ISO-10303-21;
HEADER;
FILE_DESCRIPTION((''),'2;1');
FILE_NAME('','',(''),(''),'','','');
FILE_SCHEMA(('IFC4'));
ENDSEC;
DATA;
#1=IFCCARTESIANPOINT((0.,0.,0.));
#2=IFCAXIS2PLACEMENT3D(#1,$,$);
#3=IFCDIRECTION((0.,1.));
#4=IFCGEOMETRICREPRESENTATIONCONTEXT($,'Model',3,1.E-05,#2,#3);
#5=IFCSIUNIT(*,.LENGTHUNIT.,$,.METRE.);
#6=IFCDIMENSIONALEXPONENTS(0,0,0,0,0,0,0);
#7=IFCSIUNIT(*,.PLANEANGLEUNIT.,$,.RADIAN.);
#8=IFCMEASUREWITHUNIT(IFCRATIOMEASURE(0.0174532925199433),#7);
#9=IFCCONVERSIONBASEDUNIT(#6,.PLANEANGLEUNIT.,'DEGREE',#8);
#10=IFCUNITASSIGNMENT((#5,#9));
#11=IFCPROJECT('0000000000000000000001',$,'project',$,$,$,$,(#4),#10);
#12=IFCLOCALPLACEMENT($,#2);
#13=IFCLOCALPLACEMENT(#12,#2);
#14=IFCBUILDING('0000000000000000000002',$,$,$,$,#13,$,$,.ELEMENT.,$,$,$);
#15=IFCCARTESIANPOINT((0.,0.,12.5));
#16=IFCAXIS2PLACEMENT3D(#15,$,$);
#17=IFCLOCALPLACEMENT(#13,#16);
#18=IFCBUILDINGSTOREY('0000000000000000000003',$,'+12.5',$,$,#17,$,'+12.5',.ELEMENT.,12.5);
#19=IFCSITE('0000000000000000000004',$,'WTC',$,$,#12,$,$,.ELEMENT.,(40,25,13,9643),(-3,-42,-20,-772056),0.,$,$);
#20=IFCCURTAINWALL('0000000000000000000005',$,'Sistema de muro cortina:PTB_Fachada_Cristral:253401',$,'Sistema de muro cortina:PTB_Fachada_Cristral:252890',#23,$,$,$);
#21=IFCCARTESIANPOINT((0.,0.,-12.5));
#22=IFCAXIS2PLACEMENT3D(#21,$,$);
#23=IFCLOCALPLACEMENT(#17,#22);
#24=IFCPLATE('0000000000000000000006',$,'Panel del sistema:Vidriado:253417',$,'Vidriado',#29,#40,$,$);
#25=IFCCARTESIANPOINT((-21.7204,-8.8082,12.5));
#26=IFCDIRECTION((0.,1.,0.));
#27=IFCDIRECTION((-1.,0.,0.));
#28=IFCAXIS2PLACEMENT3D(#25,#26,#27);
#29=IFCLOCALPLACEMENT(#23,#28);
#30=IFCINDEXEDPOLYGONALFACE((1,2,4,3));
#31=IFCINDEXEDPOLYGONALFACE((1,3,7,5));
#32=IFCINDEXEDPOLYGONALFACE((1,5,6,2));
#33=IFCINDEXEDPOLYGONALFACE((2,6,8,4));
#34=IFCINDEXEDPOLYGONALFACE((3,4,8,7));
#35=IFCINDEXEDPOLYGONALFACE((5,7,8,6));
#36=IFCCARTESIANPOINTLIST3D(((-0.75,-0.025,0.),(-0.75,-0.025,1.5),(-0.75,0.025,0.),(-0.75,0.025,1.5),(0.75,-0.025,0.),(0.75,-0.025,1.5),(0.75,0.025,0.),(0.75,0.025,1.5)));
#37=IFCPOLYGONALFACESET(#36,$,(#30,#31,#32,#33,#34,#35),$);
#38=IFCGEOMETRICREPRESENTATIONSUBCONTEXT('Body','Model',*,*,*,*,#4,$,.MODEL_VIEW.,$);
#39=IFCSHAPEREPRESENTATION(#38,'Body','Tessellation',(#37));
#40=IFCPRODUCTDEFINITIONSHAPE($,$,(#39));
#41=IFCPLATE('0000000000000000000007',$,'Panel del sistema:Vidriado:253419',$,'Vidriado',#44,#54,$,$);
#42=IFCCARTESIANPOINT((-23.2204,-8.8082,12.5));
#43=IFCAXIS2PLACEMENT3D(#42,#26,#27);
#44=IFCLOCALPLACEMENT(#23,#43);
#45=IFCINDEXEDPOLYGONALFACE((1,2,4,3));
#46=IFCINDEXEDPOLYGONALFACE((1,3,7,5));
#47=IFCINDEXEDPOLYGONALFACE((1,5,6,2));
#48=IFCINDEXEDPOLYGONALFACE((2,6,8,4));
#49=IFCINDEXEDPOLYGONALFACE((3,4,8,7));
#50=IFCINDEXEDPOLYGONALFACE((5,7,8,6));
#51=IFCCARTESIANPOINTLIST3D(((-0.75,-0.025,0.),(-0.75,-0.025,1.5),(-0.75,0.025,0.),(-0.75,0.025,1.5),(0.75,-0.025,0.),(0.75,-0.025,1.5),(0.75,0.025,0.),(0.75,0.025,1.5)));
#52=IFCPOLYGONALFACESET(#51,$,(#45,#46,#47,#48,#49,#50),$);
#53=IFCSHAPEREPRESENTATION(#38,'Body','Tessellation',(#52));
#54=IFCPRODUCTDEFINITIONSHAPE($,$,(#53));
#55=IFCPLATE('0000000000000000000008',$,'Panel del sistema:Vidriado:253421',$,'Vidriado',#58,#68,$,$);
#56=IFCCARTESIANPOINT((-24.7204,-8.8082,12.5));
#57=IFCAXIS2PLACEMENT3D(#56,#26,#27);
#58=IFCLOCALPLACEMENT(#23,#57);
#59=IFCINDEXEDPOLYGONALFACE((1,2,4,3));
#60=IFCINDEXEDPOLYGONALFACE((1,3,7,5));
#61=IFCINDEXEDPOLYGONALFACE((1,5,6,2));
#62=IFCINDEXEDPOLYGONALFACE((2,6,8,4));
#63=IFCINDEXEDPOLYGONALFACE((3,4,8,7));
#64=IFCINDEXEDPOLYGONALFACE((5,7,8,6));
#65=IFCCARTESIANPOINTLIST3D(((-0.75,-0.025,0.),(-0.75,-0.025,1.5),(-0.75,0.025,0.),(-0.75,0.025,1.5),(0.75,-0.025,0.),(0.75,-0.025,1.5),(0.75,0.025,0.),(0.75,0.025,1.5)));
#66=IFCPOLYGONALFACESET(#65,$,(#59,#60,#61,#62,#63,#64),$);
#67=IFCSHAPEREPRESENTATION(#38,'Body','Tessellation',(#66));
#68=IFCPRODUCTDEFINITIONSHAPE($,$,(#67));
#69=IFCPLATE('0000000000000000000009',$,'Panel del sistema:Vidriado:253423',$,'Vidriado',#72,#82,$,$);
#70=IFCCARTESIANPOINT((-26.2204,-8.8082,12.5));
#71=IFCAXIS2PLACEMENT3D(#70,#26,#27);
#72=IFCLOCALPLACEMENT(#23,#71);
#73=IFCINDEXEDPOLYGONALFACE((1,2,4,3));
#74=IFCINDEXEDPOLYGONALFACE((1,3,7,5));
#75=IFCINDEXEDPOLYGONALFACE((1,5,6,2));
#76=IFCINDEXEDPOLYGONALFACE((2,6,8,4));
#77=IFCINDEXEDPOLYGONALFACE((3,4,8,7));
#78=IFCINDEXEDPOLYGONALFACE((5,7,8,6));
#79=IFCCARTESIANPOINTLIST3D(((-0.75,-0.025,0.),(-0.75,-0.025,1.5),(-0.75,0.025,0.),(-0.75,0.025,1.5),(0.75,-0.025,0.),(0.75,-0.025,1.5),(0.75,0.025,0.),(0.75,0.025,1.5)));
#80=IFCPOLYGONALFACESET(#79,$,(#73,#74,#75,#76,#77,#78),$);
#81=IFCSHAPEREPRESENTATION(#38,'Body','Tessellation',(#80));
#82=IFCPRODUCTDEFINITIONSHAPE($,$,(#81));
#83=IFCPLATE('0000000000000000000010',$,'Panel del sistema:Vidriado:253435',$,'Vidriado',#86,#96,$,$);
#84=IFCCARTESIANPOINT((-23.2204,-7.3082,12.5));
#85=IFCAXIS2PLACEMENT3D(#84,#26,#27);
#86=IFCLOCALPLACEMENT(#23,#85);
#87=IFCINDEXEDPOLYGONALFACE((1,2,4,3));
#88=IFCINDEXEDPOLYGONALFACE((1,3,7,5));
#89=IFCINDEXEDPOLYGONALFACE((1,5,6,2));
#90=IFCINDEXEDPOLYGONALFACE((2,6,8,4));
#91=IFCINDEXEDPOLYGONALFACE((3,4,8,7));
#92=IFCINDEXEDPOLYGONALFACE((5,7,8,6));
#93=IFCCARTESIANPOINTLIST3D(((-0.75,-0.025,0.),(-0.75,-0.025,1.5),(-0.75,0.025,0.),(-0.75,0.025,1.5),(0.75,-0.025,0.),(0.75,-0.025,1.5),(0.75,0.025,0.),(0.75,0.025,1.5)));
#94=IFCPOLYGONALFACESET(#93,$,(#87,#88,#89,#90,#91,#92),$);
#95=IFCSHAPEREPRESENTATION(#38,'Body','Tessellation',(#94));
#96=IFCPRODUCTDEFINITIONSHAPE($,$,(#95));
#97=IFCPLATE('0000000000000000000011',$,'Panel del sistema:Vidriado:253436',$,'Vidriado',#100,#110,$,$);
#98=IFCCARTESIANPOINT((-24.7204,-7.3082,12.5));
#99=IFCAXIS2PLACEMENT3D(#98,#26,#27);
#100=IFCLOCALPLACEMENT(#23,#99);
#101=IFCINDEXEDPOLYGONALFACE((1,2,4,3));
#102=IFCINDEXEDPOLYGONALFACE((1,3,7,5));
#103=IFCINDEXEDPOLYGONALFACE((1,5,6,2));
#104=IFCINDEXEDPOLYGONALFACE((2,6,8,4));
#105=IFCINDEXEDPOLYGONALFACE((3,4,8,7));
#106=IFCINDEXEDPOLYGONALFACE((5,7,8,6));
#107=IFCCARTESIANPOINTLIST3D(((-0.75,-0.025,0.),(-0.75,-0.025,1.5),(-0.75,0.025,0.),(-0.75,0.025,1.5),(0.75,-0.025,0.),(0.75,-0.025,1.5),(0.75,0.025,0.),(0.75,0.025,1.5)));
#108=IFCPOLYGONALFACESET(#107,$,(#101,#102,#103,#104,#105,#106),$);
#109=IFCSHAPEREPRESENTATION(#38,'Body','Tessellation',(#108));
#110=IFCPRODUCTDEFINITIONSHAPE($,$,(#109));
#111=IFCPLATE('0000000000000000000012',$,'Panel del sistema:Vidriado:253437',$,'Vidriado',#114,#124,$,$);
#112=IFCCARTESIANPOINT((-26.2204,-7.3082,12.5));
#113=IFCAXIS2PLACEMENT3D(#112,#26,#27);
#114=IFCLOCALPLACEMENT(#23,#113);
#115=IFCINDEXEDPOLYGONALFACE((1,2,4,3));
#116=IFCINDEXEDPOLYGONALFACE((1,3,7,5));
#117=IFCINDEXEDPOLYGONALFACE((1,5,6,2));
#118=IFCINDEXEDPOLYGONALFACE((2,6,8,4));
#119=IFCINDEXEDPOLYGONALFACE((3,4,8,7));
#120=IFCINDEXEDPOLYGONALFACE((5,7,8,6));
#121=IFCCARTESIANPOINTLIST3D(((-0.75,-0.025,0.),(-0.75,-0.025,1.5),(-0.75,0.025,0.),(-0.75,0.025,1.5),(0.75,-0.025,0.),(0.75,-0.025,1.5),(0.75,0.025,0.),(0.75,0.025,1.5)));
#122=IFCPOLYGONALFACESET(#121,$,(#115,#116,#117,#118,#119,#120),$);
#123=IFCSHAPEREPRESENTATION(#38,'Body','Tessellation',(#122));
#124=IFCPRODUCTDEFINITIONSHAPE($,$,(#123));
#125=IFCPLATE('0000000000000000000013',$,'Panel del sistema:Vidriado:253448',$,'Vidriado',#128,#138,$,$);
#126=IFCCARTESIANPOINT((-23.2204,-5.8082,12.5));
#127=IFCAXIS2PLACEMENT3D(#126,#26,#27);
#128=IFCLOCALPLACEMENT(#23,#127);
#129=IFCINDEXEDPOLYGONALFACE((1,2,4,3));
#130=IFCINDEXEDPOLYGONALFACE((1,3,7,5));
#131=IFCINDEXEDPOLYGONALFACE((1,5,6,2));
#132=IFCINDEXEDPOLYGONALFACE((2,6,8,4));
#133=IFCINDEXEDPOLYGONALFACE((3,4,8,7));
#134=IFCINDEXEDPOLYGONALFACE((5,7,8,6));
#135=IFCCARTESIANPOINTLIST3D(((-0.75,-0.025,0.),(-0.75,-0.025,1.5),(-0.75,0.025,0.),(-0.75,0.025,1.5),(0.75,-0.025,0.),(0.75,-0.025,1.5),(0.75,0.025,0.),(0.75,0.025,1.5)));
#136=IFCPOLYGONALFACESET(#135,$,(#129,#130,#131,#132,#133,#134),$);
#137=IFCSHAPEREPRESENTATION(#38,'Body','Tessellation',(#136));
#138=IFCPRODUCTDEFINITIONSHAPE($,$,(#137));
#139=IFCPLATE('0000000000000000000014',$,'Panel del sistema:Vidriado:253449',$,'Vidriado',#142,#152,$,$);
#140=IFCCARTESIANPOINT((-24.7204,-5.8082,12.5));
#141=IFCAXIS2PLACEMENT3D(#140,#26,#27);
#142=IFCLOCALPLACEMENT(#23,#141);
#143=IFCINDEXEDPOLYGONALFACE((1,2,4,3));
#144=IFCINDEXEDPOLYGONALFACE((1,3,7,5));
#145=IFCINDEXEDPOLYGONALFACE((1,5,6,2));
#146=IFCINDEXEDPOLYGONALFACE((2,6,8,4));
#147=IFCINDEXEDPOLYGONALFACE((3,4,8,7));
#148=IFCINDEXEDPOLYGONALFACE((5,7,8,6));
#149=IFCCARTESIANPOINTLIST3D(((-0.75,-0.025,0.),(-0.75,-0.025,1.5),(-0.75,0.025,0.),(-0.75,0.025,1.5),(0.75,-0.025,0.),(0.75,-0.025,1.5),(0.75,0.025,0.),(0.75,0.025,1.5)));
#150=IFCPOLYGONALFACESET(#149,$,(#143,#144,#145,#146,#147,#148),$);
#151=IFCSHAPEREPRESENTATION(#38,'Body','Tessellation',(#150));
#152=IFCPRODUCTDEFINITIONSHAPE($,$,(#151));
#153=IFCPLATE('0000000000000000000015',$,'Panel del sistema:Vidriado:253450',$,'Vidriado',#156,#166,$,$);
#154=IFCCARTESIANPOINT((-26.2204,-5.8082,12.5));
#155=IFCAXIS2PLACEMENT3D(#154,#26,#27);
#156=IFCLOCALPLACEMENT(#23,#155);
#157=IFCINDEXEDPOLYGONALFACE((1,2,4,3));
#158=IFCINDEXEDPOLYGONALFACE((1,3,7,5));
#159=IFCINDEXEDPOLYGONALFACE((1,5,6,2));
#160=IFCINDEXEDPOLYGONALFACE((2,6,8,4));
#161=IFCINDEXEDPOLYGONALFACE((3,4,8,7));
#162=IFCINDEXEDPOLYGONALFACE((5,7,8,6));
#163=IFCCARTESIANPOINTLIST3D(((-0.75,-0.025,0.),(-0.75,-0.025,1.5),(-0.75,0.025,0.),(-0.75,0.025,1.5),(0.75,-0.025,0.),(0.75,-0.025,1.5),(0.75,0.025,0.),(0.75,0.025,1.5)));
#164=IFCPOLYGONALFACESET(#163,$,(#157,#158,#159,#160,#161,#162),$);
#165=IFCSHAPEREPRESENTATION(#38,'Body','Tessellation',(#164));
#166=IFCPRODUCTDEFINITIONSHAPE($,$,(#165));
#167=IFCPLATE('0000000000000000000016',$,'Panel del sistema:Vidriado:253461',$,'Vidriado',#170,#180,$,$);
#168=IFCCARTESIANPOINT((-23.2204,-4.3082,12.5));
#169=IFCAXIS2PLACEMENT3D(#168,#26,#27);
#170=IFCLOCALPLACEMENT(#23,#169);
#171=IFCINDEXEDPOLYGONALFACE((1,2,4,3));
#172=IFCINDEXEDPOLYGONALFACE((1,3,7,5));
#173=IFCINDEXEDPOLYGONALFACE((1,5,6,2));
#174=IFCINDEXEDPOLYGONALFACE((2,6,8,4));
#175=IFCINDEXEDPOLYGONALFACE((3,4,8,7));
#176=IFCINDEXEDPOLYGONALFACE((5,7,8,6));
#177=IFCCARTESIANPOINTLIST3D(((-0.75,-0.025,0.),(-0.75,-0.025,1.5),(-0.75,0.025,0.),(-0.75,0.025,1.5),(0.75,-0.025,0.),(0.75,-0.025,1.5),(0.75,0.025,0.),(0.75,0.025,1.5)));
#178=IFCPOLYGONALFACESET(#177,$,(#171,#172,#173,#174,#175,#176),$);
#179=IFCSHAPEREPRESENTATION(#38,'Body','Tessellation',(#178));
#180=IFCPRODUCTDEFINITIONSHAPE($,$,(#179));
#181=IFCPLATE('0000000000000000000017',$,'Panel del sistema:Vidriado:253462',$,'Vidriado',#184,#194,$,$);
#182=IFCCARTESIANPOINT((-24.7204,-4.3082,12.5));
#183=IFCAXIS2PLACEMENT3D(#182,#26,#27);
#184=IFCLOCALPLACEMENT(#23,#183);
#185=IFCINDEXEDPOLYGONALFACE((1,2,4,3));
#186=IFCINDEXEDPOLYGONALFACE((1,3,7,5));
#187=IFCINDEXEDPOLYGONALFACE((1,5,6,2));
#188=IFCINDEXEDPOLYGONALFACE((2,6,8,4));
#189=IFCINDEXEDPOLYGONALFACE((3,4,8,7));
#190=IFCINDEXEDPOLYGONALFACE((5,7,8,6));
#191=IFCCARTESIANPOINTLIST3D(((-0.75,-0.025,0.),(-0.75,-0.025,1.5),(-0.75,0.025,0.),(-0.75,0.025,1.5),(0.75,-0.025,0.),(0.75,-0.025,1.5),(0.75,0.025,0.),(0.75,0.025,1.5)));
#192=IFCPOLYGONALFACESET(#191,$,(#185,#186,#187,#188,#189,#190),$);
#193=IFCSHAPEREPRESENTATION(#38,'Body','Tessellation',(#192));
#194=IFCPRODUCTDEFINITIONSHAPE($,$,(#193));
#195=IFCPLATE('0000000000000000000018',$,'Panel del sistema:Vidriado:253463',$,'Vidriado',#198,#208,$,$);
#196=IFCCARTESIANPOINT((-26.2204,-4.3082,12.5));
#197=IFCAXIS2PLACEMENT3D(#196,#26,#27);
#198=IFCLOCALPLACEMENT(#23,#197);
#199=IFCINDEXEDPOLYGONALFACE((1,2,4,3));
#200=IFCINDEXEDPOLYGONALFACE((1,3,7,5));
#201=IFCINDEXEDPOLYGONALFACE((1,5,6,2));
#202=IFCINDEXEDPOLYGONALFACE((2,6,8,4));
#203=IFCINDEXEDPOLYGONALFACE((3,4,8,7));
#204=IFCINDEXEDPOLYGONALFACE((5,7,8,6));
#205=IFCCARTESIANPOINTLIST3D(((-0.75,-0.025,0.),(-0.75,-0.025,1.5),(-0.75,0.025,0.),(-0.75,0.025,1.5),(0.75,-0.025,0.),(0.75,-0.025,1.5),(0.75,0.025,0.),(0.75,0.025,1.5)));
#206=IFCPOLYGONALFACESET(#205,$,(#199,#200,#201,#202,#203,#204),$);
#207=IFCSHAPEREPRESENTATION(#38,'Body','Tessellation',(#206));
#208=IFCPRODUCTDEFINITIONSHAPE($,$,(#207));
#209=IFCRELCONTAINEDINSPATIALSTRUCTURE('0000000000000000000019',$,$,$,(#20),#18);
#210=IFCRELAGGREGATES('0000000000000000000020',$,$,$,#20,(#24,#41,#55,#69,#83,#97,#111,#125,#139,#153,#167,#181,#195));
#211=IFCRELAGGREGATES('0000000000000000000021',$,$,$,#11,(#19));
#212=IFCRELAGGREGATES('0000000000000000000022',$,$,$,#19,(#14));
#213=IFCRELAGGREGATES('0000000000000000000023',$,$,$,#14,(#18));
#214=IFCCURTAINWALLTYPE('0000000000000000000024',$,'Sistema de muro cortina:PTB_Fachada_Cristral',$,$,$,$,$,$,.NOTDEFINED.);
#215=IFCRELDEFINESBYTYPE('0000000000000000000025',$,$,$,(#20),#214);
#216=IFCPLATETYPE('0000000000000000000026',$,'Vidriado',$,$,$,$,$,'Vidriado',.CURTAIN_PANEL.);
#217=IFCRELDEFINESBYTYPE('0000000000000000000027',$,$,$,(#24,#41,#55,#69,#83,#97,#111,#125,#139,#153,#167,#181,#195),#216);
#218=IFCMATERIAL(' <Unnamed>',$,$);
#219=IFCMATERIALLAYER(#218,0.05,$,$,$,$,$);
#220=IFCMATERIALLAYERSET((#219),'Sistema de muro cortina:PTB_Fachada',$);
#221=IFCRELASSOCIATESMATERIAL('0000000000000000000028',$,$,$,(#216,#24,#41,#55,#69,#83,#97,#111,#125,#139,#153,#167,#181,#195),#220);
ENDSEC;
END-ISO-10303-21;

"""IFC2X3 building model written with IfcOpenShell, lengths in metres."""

from ifc_helpers import new_model, entity, si_unit, converted_unit, direction, frame, origin, origin_2d_with_axis, place, context, subcontext, project, spatial, rectangle, extrude, source, transform, mapped, material, layer, layer_set, layer_usage, type_object, type_shapes, element, aggregate, save


model = new_model("IFC2X3")

# Units and contexts
model_context = context("Model", 3, precision=1e-05, world=origin(), true_north=direction((0.0, 1.0)))
body_context = subcontext(model_context, "Body", "Model", "MODEL_VIEW")
ifc_project = project(units=[si_unit("LENGTHUNIT", "METRE"), converted_unit("PLANEANGLEUNIT", "DEGREE", entity("IfcRatioMeasure", 0.0174532925199433), si_unit("PLANEANGLEUNIT", "RADIAN"), dimensions=[0, 0, 0, 0, 0, 0, 0])], contexts=[model_context])

# Site, building, storey
site_placement = place(None, origin())
site = spatial("IfcSite", under=ifc_project, at=site_placement, Name="WTC", CompositionType="ELEMENT", RefLatitude=(40, 25, 13, 9643), RefLongitude=(-3, -42, -20, -772056), RefElevation=0.0)
building_placement = place(site_placement, origin())
building = spatial("IfcBuilding", under=site, at=building_placement, CompositionType="ELEMENT")
storey_placement = place(building_placement, frame((0.0, 0.0, 12.5)))
storey = spatial("IfcBuildingStorey", under=building, at=storey_placement, Name="+12.5", LongName="+12.5", CompositionType="ELEMENT", Elevation=12.5)

# Curtain wall, plates
curtain_wall_type = type_object("IfcCurtainWallType", Name="Sistema de muro cortina:PTB_Fachada_Cristral", PredefinedType="NOTDEFINED")
curtain_wall_placement = place(storey_placement, frame((0.0, 0.0, -12.5)))
curtain_wall = element("IfcCurtainWall", 1, at=curtain_wall_placement, inside=storey, type_object=curtain_wall_type, Name="Sistema de muro cortina:PTB_Fachada_Cristral:253401", ObjectType="Sistema de muro cortina:PTB_Fachada_Cristral:252890")
ifc_material = material(Name=" <Unnamed>")
ifc_layer = layer(ifc_material, 0.05)
ifc_layer_set = layer_set([ifc_layer], Name="Sistema de muro cortina:PTB_Fachada")
ifc_layer_usage_1 = layer_usage(ifc_layer_set, "AXIS3", "POSITIVE", 0.0)
plate_type_1 = type_object("IfcPlateType", Name="Vidriado", ElementType="Vidriado", PredefinedType="CURTAIN_PANEL", material=ifc_layer_set)
shared_shape_1 = source(origin(), body_context, "Body", "SweptSolid", [
    extrude(rectangle(XDim=0.05, YDim=1.5, at=origin_2d_with_axis()), frame((0.0, 0.0, 0.0), z_axis=(0.0, 0.0, 1.0), x_axis=(0.0, 1.0, 0.0)), (0.0, 0.0, 1.0), 1.5),
])
type_shapes(plate_type_1, [shared_shape_1])
plate_1_placement = place(curtain_wall_placement, frame((-21.7204, -8.8082, 12.5), z_axis=(0.0, 1.0, 0.0), x_axis=(-1.0, 0.0, 0.0)))
plate_1 = element("IfcPlate", 2, at=plate_1_placement, type_object=plate_type_1, material=ifc_layer_usage_1, Name="Panel del sistema:Vidriado:253417", ObjectType="Vidriado", context=body_context, shape_type="MappedRepresentation", body=[
    mapped(shared_shape_1, transform((0.0, 0.0, 0.0), scale=1.0)),
])
ifc_layer_usage_2 = layer_usage(ifc_layer_set, "AXIS3", "POSITIVE", 0.0)
plate_2_placement = place(curtain_wall_placement, frame((-23.2204, -8.8082, 12.5), z_axis=(0.0, 1.0, 0.0), x_axis=(-1.0, 0.0, 0.0)))
plate_2 = element("IfcPlate", 3, at=plate_2_placement, type_object=plate_type_1, material=ifc_layer_usage_2, Name="Panel del sistema:Vidriado:253419", ObjectType="Vidriado", context=body_context, shape_type="MappedRepresentation", body=[
    mapped(shared_shape_1, transform((0.0, 0.0, 0.0), scale=1.0)),
])
ifc_layer_usage_3 = layer_usage(ifc_layer_set, "AXIS3", "POSITIVE", 0.0)
plate_3_placement = place(curtain_wall_placement, frame((-24.7204, -8.8082, 12.5), z_axis=(0.0, 1.0, 0.0), x_axis=(-1.0, 0.0, 0.0)))
plate_3 = element("IfcPlate", 4, at=plate_3_placement, type_object=plate_type_1, material=ifc_layer_usage_3, Name="Panel del sistema:Vidriado:253421", ObjectType="Vidriado", context=body_context, shape_type="MappedRepresentation", body=[
    mapped(shared_shape_1, transform((0.0, 0.0, 0.0), scale=1.0)),
])
ifc_layer_usage_4 = layer_usage(ifc_layer_set, "AXIS3", "POSITIVE", 0.0)
plate_4_placement = place(curtain_wall_placement, frame((-26.2204, -8.8082, 12.5), z_axis=(0.0, 1.0, 0.0), x_axis=(-1.0, 0.0, 0.0)))
plate_4 = element("IfcPlate", 5, at=plate_4_placement, type_object=plate_type_1, material=ifc_layer_usage_4, Name="Panel del sistema:Vidriado:253423", ObjectType="Vidriado", context=body_context, shape_type="MappedRepresentation", body=[
    mapped(shared_shape_1, transform((0.0, 0.0, 0.0), scale=1.0)),
])
ifc_layer_usage_5 = layer_usage(ifc_layer_set, "AXIS3", "POSITIVE", 0.0)
plate_5_placement = place(curtain_wall_placement, frame((-23.2204, -7.3082, 12.5), z_axis=(0.0, 1.0, 0.0), x_axis=(-1.0, 0.0, 0.0)))
plate_5 = element("IfcPlate", 6, at=plate_5_placement, type_object=plate_type_1, material=ifc_layer_usage_5, Name="Panel del sistema:Vidriado:253435", ObjectType="Vidriado", context=body_context, shape_type="MappedRepresentation", body=[
    mapped(shared_shape_1, transform((0.0, 0.0, 0.0), scale=1.0)),
])
ifc_layer_usage_6 = layer_usage(ifc_layer_set, "AXIS3", "POSITIVE", 0.0)
plate_6_placement = place(curtain_wall_placement, frame((-24.7204, -7.3082, 12.5), z_axis=(0.0, 1.0, 0.0), x_axis=(-1.0, 0.0, 0.0)))
plate_6 = element("IfcPlate", 7, at=plate_6_placement, type_object=plate_type_1, material=ifc_layer_usage_6, Name="Panel del sistema:Vidriado:253436", ObjectType="Vidriado", context=body_context, shape_type="MappedRepresentation", body=[
    mapped(shared_shape_1, transform((0.0, 0.0, 0.0), scale=1.0)),
])
ifc_layer_usage_7 = layer_usage(ifc_layer_set, "AXIS3", "POSITIVE", 0.0)
plate_7_placement = place(curtain_wall_placement, frame((-26.2204, -7.3082, 12.5), z_axis=(0.0, 1.0, 0.0), x_axis=(-1.0, 0.0, 0.0)))
plate_7 = element("IfcPlate", 8, at=plate_7_placement, type_object=plate_type_1, material=ifc_layer_usage_7, Name="Panel del sistema:Vidriado:253437", ObjectType="Vidriado", context=body_context, shape_type="MappedRepresentation", body=[
    mapped(shared_shape_1, transform((0.0, 0.0, 0.0), scale=1.0)),
])
ifc_layer_usage_8 = layer_usage(ifc_layer_set, "AXIS3", "POSITIVE", 0.0)
plate_8_placement = place(curtain_wall_placement, frame((-23.2204, -5.8082, 12.5), z_axis=(0.0, 1.0, 0.0), x_axis=(-1.0, 0.0, 0.0)))
plate_8 = element("IfcPlate", 9, at=plate_8_placement, type_object=plate_type_1, material=ifc_layer_usage_8, Name="Panel del sistema:Vidriado:253448", ObjectType="Vidriado", context=body_context, shape_type="MappedRepresentation", body=[
    mapped(shared_shape_1, transform((0.0, 0.0, 0.0), scale=1.0)),
])
ifc_layer_usage_9 = layer_usage(ifc_layer_set, "AXIS3", "POSITIVE", 0.0)
plate_9_placement = place(curtain_wall_placement, frame((-24.7204, -5.8082, 12.5), z_axis=(0.0, 1.0, 0.0), x_axis=(-1.0, 0.0, 0.0)))
plate_9 = element("IfcPlate", 10, at=plate_9_placement, type_object=plate_type_1, material=ifc_layer_usage_9, Name="Panel del sistema:Vidriado:253449", ObjectType="Vidriado", context=body_context, shape_type="MappedRepresentation", body=[
    mapped(shared_shape_1, transform((0.0, 0.0, 0.0), scale=1.0)),
])
ifc_layer_usage_10 = layer_usage(ifc_layer_set, "AXIS3", "POSITIVE", 0.0)
plate_10_placement = place(curtain_wall_placement, frame((-26.2204, -5.8082, 12.5), z_axis=(0.0, 1.0, 0.0), x_axis=(-1.0, 0.0, 0.0)))
plate_10 = element("IfcPlate", 11, at=plate_10_placement, type_object=plate_type_1, material=ifc_layer_usage_10, Name="Panel del sistema:Vidriado:253450", ObjectType="Vidriado", context=body_context, shape_type="MappedRepresentation", body=[
    mapped(shared_shape_1, transform((0.0, 0.0, 0.0), scale=1.0)),
])
ifc_layer_usage_11 = layer_usage(ifc_layer_set, "AXIS3", "POSITIVE", 0.0)
plate_11_placement = place(curtain_wall_placement, frame((-23.2204, -4.3082, 12.5), z_axis=(0.0, 1.0, 0.0), x_axis=(-1.0, 0.0, 0.0)))
plate_11 = element("IfcPlate", 12, at=plate_11_placement, type_object=plate_type_1, material=ifc_layer_usage_11, Name="Panel del sistema:Vidriado:253461", ObjectType="Vidriado", context=body_context, shape_type="MappedRepresentation", body=[
    mapped(shared_shape_1, transform((0.0, 0.0, 0.0), scale=1.0)),
])
ifc_layer_usage_12 = layer_usage(ifc_layer_set, "AXIS3", "POSITIVE", 0.0)
plate_12_placement = place(curtain_wall_placement, frame((-24.7204, -4.3082, 12.5), z_axis=(0.0, 1.0, 0.0), x_axis=(-1.0, 0.0, 0.0)))
plate_12 = element("IfcPlate", 13, at=plate_12_placement, type_object=plate_type_1, material=ifc_layer_usage_12, Name="Panel del sistema:Vidriado:253462", ObjectType="Vidriado", context=body_context, shape_type="MappedRepresentation", body=[
    mapped(shared_shape_1, transform((0.0, 0.0, 0.0), scale=1.0)),
])
ifc_layer_usage_13 = layer_usage(ifc_layer_set, "AXIS3", "POSITIVE", 0.0)
plate_13_placement = place(curtain_wall_placement, frame((-26.2204, -4.3082, 12.5), z_axis=(0.0, 1.0, 0.0), x_axis=(-1.0, 0.0, 0.0)))
plate_13 = element("IfcPlate", 14, at=plate_13_placement, type_object=plate_type_1, material=ifc_layer_usage_13, Name="Panel del sistema:Vidriado:253463", ObjectType="Vidriado", context=body_context, shape_type="MappedRepresentation", body=[
    mapped(shared_shape_1, transform((0.0, 0.0, 0.0), scale=1.0)),
])
aggregate(curtain_wall, [plate_1, plate_2, plate_3, plate_4, plate_5, plate_6, plate_7, plate_8, plate_9, plate_10, plate_11, plate_12, plate_13])

save(model, "model.ifc")
